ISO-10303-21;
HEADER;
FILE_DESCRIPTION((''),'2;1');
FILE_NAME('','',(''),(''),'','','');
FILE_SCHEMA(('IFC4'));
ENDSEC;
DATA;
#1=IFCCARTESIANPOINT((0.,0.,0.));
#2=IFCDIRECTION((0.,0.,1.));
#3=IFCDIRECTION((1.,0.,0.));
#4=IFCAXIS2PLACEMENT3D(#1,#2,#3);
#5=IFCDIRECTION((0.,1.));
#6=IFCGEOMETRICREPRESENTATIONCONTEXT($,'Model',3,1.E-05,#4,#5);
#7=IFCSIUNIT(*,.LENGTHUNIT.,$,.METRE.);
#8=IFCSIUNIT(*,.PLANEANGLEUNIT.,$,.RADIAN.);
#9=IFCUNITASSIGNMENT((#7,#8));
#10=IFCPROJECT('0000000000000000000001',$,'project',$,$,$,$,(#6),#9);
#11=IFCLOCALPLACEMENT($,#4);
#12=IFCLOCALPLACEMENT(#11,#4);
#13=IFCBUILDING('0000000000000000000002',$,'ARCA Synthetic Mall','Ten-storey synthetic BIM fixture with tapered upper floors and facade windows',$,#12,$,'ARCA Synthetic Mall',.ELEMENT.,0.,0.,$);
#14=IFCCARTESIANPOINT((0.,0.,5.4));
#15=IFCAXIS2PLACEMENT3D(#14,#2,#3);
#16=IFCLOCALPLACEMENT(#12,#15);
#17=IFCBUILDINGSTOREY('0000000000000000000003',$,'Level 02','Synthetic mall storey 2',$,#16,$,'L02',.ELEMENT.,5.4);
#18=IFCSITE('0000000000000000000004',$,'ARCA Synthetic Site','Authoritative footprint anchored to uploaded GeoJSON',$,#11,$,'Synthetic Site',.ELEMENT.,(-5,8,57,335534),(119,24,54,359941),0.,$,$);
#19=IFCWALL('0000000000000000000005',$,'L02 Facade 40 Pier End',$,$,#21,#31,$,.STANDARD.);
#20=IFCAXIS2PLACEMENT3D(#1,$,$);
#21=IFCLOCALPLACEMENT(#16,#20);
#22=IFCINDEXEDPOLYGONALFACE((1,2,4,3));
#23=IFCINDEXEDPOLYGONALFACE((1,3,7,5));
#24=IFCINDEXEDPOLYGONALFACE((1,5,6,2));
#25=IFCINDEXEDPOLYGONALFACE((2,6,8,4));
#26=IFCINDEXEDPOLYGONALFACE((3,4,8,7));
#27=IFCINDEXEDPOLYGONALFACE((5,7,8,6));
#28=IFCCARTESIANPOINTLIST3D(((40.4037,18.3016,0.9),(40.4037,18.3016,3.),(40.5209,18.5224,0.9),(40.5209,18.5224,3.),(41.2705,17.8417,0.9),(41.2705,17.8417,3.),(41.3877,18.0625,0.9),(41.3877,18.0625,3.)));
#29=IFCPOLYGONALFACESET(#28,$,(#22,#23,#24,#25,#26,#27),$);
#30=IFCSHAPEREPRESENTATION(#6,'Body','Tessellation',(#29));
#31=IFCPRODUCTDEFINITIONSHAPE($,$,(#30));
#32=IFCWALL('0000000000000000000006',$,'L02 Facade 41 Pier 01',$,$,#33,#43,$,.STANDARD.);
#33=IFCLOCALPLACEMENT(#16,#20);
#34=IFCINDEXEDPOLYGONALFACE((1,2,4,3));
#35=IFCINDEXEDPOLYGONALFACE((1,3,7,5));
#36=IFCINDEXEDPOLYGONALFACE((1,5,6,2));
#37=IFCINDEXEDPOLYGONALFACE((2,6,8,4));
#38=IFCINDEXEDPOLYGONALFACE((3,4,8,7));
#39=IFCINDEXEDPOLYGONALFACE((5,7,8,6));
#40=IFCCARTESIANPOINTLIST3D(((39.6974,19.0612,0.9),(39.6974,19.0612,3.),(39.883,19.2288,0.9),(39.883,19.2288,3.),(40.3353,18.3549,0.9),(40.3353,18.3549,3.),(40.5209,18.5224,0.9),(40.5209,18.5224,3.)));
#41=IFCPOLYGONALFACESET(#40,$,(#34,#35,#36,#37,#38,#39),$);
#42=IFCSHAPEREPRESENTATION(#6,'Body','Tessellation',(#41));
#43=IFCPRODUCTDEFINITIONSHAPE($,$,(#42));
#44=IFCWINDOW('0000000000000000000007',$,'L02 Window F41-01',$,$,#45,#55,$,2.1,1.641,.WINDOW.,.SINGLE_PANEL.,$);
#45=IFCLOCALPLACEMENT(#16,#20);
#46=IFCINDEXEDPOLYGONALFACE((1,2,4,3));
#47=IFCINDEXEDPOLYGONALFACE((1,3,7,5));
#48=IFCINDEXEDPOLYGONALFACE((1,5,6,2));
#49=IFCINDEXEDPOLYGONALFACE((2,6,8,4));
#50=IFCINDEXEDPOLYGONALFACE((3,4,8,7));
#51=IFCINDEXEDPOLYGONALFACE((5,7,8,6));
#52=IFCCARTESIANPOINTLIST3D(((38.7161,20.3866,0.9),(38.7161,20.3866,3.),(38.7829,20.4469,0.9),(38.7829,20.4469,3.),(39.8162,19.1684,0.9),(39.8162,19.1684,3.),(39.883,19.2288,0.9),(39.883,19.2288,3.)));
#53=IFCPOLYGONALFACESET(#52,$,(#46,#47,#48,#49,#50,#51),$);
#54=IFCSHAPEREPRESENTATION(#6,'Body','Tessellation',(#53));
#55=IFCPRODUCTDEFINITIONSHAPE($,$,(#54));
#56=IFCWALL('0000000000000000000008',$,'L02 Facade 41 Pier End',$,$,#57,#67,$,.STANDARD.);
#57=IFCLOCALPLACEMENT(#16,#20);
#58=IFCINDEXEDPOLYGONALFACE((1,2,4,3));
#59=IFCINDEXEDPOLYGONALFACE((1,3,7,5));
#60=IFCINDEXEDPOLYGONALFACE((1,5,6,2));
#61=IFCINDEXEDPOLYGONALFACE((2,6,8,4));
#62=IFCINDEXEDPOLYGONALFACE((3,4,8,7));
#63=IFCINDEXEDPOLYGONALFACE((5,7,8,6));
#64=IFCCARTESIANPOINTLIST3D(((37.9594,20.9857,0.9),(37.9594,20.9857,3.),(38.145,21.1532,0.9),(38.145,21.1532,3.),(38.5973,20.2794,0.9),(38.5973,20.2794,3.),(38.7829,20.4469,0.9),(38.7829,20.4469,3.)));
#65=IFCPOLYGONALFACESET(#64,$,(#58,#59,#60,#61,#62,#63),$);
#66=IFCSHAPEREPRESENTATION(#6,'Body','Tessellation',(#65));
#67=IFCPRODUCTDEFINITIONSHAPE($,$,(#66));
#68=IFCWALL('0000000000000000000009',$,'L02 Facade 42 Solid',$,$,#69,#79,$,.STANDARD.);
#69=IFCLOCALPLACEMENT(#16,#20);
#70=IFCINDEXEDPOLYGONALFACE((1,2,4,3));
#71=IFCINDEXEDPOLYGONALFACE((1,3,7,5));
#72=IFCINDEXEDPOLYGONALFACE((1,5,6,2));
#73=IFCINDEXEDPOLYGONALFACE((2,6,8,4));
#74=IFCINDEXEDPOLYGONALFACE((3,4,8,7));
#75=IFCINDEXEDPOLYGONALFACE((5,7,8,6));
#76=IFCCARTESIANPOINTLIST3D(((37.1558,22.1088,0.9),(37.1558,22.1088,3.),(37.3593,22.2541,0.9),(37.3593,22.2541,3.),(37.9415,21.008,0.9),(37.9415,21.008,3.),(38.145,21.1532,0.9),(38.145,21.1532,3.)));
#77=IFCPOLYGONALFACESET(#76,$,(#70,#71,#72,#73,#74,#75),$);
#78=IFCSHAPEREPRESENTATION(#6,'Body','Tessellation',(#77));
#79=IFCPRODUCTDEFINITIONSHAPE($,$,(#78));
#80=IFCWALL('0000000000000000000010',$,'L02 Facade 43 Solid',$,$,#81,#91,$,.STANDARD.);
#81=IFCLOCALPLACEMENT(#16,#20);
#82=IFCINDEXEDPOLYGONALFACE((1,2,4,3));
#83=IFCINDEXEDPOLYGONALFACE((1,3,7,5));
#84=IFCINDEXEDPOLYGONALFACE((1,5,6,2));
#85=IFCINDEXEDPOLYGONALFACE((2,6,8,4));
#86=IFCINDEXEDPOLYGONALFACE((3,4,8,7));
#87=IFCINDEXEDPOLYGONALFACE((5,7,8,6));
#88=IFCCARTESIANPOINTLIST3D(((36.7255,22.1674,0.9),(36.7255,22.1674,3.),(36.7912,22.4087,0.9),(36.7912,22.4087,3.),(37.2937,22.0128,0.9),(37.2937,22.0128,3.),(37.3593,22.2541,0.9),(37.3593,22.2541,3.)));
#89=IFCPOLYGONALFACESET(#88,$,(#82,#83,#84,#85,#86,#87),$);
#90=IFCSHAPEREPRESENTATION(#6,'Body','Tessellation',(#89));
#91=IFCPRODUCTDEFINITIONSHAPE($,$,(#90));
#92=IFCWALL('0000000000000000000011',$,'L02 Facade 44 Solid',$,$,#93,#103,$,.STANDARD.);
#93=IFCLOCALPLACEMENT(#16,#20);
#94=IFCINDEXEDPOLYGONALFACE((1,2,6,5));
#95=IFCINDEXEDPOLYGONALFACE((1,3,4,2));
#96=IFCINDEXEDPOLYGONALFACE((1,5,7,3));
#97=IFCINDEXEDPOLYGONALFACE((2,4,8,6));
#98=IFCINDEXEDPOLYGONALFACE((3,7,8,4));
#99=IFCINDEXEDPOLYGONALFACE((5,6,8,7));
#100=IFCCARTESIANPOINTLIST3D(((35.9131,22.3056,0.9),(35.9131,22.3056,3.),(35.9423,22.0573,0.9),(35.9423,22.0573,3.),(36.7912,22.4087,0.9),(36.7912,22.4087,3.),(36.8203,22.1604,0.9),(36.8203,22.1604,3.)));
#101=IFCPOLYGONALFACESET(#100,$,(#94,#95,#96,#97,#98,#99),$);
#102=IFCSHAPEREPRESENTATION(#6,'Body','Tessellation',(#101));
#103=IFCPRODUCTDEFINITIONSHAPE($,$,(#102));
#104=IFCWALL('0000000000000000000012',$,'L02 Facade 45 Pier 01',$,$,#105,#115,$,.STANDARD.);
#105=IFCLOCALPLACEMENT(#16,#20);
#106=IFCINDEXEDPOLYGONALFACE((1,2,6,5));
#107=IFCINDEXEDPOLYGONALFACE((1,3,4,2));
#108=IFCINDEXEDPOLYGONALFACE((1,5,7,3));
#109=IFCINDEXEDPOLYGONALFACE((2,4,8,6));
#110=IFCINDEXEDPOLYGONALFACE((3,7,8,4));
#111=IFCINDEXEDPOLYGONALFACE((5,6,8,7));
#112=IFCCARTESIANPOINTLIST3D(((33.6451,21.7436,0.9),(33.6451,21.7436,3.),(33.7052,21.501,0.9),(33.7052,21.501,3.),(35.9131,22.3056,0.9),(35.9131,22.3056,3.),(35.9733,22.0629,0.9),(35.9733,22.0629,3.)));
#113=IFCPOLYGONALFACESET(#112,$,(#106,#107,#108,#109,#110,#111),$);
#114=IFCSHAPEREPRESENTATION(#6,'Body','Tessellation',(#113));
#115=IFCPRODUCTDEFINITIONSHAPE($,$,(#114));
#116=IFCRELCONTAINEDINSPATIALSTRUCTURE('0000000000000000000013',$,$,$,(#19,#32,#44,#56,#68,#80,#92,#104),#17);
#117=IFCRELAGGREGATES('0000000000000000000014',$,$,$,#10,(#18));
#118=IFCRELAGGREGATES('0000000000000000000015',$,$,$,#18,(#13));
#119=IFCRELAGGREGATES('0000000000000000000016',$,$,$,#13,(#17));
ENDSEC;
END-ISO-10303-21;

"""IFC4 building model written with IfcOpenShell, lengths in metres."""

from ifc_helpers import new_model, si_unit, direction, frame, origin_with_axes, place, context, project, spatial, polyline, outline, extrude, element, save


model = new_model("IFC4")

# Units and contexts
model_context = context("Model", 3, precision=1e-05, world=origin_with_axes(), true_north=direction((0.0, 1.0)))
ifc_project = project(units=[si_unit("LENGTHUNIT", "METRE"), si_unit("PLANEANGLEUNIT", "RADIAN")], contexts=[model_context])

# Site, building, storey
site_placement = place(None, origin_with_axes())
site = spatial("IfcSite", under=ifc_project, at=site_placement, Name="ARCA Synthetic Site", Description="Authoritative footprint anchored to uploaded GeoJSON", LongName="Synthetic Site", CompositionType="ELEMENT", RefLatitude=(-5, 8, 57, 335534), RefLongitude=(119, 24, 54, 359941), RefElevation=0.0)
building_placement = place(site_placement, origin_with_axes())
building = spatial("IfcBuilding", under=site, at=building_placement, Name="ARCA Synthetic Mall", Description="Ten-storey synthetic BIM fixture with tapered upper floors and facade windows", LongName="ARCA Synthetic Mall", CompositionType="ELEMENT", ElevationOfRefHeight=0.0, ElevationOfTerrain=0.0)
storey_placement = place(building_placement, frame((0.0, 0.0, 5.4), z_axis=(0.0, 0.0, 1.0), x_axis=(1.0, 0.0, 0.0)))
storey = spatial("IfcBuildingStorey", under=building, at=storey_placement, Name="Level 02", Description="Synthetic mall storey 2", LongName="L02", CompositionType="ELEMENT", Elevation=5.4)

# Walls
wall_1_placement = place(storey_placement, frame((0.0, 0.0, 0.9), z_axis=(0.0, 0.0, 1.0), x_axis=(1.0, 0.0, 0.0)))
element("IfcWall", 1, at=wall_1_placement, inside=storey, Name="L02 Facade 40 Pier End", PredefinedType="STANDARD", context=model_context, shape_type="SweptSolid", body=[
    extrude(outline(polyline([(41.3877, 18.0625), (40.5209, 18.5224), (40.4037, 18.3016), (41.2705, 17.8417), (41.3877, 18.0625)])), origin_with_axes(), (0.0, 0.0, 1.0), 2.1),
])
wall_2_placement = place(storey_placement, frame((0.0, 0.0, 0.9), z_axis=(0.0, 0.0, 1.0), x_axis=(1.0, 0.0, 0.0)))
element("IfcWall", 2, at=wall_2_placement, inside=storey, Name="L02 Facade 41 Pier 01", PredefinedType="STANDARD", context=model_context, shape_type="SweptSolid", body=[
    extrude(outline(polyline([(40.5209, 18.5224), (39.883, 19.2288), (39.6974, 19.0612), (40.3353, 18.3549), (40.5209, 18.5224)])), origin_with_axes(), (0.0, 0.0, 1.0), 2.1),
])

# Window
window_1_placement = place(storey_placement, frame((0.0, 0.0, 0.9), z_axis=(0.0, 0.0, 1.0), x_axis=(1.0, 0.0, 0.0)))
element("IfcWindow", 3, at=window_1_placement, inside=storey, Name="L02 Window F41-01", OverallHeight=2.1, OverallWidth=1.641, PartitioningType="SINGLE_PANEL", PredefinedType="WINDOW", context=model_context, shape_type="SweptSolid", body=[
    extrude(outline(polyline([(39.883, 19.2288), (38.7829, 20.4469), (38.7161, 20.3866), (39.8162, 19.1684), (39.883, 19.2288)])), origin_with_axes(), (0.0, 0.0, 1.0), 2.1),
])

# Walls
wall_3_placement = place(storey_placement, frame((0.0, 0.0, 0.9), z_axis=(0.0, 0.0, 1.0), x_axis=(1.0, 0.0, 0.0)))
element("IfcWall", 4, at=wall_3_placement, inside=storey, Name="L02 Facade 41 Pier End", PredefinedType="STANDARD", context=model_context, shape_type="SweptSolid", body=[
    extrude(outline(polyline([(38.7829, 20.4469), (38.145, 21.1532), (37.9594, 20.9857), (38.5973, 20.2794), (38.7829, 20.4469)])), origin_with_axes(), (0.0, 0.0, 1.0), 2.1),
])
wall_4_placement = place(storey_placement, frame((0.0, 0.0, 0.9), z_axis=(0.0, 0.0, 1.0), x_axis=(1.0, 0.0, 0.0)))
element("IfcWall", 5, at=wall_4_placement, inside=storey, Name="L02 Facade 42 Solid", PredefinedType="STANDARD", context=model_context, shape_type="SweptSolid", body=[
    extrude(outline(polyline([(38.145, 21.1532), (37.3593, 22.2541), (37.1558, 22.1088), (37.9415, 21.008), (38.145, 21.1532)])), origin_with_axes(), (0.0, 0.0, 1.0), 2.1),
])
wall_5_placement = place(storey_placement, frame((0.0, 0.0, 0.9), z_axis=(0.0, 0.0, 1.0), x_axis=(1.0, 0.0, 0.0)))
element("IfcWall", 6, at=wall_5_placement, inside=storey, Name="L02 Facade 43 Solid", PredefinedType="STANDARD", context=model_context, shape_type="SweptSolid", body=[
    extrude(outline(polyline([(37.3593, 22.2541), (36.7912, 22.4087), (36.7255, 22.1674), (37.2937, 22.0128), (37.3593, 22.2541)])), origin_with_axes(), (0.0, 0.0, 1.0), 2.1),
])
wall_6_placement = place(storey_placement, frame((0.0, 0.0, 0.9), z_axis=(0.0, 0.0, 1.0), x_axis=(1.0, 0.0, 0.0)))
element("IfcWall", 7, at=wall_6_placement, inside=storey, Name="L02 Facade 44 Solid", PredefinedType="STANDARD", context=model_context, shape_type="SweptSolid", body=[
    extrude(outline(polyline([(36.7912, 22.4087), (35.9131, 22.3056), (35.9423, 22.0573), (36.8203, 22.1604), (36.7912, 22.4087)])), origin_with_axes(), (0.0, 0.0, 1.0), 2.1),
])
wall_7_placement = place(storey_placement, frame((0.0, 0.0, 0.9), z_axis=(0.0, 0.0, 1.0), x_axis=(1.0, 0.0, 0.0)))
element("IfcWall", 8, at=wall_7_placement, inside=storey, Name="L02 Facade 45 Pier 01", PredefinedType="STANDARD", context=model_context, shape_type="SweptSolid", body=[
    extrude(outline(polyline([(35.9131, 22.3056), (33.6451, 21.7436), (33.7052, 21.501), (35.9733, 22.0629), (35.9131, 22.3056)])), origin_with_axes(), (0.0, 0.0, 1.0), 2.1),
])

save(model, "model.ifc")
